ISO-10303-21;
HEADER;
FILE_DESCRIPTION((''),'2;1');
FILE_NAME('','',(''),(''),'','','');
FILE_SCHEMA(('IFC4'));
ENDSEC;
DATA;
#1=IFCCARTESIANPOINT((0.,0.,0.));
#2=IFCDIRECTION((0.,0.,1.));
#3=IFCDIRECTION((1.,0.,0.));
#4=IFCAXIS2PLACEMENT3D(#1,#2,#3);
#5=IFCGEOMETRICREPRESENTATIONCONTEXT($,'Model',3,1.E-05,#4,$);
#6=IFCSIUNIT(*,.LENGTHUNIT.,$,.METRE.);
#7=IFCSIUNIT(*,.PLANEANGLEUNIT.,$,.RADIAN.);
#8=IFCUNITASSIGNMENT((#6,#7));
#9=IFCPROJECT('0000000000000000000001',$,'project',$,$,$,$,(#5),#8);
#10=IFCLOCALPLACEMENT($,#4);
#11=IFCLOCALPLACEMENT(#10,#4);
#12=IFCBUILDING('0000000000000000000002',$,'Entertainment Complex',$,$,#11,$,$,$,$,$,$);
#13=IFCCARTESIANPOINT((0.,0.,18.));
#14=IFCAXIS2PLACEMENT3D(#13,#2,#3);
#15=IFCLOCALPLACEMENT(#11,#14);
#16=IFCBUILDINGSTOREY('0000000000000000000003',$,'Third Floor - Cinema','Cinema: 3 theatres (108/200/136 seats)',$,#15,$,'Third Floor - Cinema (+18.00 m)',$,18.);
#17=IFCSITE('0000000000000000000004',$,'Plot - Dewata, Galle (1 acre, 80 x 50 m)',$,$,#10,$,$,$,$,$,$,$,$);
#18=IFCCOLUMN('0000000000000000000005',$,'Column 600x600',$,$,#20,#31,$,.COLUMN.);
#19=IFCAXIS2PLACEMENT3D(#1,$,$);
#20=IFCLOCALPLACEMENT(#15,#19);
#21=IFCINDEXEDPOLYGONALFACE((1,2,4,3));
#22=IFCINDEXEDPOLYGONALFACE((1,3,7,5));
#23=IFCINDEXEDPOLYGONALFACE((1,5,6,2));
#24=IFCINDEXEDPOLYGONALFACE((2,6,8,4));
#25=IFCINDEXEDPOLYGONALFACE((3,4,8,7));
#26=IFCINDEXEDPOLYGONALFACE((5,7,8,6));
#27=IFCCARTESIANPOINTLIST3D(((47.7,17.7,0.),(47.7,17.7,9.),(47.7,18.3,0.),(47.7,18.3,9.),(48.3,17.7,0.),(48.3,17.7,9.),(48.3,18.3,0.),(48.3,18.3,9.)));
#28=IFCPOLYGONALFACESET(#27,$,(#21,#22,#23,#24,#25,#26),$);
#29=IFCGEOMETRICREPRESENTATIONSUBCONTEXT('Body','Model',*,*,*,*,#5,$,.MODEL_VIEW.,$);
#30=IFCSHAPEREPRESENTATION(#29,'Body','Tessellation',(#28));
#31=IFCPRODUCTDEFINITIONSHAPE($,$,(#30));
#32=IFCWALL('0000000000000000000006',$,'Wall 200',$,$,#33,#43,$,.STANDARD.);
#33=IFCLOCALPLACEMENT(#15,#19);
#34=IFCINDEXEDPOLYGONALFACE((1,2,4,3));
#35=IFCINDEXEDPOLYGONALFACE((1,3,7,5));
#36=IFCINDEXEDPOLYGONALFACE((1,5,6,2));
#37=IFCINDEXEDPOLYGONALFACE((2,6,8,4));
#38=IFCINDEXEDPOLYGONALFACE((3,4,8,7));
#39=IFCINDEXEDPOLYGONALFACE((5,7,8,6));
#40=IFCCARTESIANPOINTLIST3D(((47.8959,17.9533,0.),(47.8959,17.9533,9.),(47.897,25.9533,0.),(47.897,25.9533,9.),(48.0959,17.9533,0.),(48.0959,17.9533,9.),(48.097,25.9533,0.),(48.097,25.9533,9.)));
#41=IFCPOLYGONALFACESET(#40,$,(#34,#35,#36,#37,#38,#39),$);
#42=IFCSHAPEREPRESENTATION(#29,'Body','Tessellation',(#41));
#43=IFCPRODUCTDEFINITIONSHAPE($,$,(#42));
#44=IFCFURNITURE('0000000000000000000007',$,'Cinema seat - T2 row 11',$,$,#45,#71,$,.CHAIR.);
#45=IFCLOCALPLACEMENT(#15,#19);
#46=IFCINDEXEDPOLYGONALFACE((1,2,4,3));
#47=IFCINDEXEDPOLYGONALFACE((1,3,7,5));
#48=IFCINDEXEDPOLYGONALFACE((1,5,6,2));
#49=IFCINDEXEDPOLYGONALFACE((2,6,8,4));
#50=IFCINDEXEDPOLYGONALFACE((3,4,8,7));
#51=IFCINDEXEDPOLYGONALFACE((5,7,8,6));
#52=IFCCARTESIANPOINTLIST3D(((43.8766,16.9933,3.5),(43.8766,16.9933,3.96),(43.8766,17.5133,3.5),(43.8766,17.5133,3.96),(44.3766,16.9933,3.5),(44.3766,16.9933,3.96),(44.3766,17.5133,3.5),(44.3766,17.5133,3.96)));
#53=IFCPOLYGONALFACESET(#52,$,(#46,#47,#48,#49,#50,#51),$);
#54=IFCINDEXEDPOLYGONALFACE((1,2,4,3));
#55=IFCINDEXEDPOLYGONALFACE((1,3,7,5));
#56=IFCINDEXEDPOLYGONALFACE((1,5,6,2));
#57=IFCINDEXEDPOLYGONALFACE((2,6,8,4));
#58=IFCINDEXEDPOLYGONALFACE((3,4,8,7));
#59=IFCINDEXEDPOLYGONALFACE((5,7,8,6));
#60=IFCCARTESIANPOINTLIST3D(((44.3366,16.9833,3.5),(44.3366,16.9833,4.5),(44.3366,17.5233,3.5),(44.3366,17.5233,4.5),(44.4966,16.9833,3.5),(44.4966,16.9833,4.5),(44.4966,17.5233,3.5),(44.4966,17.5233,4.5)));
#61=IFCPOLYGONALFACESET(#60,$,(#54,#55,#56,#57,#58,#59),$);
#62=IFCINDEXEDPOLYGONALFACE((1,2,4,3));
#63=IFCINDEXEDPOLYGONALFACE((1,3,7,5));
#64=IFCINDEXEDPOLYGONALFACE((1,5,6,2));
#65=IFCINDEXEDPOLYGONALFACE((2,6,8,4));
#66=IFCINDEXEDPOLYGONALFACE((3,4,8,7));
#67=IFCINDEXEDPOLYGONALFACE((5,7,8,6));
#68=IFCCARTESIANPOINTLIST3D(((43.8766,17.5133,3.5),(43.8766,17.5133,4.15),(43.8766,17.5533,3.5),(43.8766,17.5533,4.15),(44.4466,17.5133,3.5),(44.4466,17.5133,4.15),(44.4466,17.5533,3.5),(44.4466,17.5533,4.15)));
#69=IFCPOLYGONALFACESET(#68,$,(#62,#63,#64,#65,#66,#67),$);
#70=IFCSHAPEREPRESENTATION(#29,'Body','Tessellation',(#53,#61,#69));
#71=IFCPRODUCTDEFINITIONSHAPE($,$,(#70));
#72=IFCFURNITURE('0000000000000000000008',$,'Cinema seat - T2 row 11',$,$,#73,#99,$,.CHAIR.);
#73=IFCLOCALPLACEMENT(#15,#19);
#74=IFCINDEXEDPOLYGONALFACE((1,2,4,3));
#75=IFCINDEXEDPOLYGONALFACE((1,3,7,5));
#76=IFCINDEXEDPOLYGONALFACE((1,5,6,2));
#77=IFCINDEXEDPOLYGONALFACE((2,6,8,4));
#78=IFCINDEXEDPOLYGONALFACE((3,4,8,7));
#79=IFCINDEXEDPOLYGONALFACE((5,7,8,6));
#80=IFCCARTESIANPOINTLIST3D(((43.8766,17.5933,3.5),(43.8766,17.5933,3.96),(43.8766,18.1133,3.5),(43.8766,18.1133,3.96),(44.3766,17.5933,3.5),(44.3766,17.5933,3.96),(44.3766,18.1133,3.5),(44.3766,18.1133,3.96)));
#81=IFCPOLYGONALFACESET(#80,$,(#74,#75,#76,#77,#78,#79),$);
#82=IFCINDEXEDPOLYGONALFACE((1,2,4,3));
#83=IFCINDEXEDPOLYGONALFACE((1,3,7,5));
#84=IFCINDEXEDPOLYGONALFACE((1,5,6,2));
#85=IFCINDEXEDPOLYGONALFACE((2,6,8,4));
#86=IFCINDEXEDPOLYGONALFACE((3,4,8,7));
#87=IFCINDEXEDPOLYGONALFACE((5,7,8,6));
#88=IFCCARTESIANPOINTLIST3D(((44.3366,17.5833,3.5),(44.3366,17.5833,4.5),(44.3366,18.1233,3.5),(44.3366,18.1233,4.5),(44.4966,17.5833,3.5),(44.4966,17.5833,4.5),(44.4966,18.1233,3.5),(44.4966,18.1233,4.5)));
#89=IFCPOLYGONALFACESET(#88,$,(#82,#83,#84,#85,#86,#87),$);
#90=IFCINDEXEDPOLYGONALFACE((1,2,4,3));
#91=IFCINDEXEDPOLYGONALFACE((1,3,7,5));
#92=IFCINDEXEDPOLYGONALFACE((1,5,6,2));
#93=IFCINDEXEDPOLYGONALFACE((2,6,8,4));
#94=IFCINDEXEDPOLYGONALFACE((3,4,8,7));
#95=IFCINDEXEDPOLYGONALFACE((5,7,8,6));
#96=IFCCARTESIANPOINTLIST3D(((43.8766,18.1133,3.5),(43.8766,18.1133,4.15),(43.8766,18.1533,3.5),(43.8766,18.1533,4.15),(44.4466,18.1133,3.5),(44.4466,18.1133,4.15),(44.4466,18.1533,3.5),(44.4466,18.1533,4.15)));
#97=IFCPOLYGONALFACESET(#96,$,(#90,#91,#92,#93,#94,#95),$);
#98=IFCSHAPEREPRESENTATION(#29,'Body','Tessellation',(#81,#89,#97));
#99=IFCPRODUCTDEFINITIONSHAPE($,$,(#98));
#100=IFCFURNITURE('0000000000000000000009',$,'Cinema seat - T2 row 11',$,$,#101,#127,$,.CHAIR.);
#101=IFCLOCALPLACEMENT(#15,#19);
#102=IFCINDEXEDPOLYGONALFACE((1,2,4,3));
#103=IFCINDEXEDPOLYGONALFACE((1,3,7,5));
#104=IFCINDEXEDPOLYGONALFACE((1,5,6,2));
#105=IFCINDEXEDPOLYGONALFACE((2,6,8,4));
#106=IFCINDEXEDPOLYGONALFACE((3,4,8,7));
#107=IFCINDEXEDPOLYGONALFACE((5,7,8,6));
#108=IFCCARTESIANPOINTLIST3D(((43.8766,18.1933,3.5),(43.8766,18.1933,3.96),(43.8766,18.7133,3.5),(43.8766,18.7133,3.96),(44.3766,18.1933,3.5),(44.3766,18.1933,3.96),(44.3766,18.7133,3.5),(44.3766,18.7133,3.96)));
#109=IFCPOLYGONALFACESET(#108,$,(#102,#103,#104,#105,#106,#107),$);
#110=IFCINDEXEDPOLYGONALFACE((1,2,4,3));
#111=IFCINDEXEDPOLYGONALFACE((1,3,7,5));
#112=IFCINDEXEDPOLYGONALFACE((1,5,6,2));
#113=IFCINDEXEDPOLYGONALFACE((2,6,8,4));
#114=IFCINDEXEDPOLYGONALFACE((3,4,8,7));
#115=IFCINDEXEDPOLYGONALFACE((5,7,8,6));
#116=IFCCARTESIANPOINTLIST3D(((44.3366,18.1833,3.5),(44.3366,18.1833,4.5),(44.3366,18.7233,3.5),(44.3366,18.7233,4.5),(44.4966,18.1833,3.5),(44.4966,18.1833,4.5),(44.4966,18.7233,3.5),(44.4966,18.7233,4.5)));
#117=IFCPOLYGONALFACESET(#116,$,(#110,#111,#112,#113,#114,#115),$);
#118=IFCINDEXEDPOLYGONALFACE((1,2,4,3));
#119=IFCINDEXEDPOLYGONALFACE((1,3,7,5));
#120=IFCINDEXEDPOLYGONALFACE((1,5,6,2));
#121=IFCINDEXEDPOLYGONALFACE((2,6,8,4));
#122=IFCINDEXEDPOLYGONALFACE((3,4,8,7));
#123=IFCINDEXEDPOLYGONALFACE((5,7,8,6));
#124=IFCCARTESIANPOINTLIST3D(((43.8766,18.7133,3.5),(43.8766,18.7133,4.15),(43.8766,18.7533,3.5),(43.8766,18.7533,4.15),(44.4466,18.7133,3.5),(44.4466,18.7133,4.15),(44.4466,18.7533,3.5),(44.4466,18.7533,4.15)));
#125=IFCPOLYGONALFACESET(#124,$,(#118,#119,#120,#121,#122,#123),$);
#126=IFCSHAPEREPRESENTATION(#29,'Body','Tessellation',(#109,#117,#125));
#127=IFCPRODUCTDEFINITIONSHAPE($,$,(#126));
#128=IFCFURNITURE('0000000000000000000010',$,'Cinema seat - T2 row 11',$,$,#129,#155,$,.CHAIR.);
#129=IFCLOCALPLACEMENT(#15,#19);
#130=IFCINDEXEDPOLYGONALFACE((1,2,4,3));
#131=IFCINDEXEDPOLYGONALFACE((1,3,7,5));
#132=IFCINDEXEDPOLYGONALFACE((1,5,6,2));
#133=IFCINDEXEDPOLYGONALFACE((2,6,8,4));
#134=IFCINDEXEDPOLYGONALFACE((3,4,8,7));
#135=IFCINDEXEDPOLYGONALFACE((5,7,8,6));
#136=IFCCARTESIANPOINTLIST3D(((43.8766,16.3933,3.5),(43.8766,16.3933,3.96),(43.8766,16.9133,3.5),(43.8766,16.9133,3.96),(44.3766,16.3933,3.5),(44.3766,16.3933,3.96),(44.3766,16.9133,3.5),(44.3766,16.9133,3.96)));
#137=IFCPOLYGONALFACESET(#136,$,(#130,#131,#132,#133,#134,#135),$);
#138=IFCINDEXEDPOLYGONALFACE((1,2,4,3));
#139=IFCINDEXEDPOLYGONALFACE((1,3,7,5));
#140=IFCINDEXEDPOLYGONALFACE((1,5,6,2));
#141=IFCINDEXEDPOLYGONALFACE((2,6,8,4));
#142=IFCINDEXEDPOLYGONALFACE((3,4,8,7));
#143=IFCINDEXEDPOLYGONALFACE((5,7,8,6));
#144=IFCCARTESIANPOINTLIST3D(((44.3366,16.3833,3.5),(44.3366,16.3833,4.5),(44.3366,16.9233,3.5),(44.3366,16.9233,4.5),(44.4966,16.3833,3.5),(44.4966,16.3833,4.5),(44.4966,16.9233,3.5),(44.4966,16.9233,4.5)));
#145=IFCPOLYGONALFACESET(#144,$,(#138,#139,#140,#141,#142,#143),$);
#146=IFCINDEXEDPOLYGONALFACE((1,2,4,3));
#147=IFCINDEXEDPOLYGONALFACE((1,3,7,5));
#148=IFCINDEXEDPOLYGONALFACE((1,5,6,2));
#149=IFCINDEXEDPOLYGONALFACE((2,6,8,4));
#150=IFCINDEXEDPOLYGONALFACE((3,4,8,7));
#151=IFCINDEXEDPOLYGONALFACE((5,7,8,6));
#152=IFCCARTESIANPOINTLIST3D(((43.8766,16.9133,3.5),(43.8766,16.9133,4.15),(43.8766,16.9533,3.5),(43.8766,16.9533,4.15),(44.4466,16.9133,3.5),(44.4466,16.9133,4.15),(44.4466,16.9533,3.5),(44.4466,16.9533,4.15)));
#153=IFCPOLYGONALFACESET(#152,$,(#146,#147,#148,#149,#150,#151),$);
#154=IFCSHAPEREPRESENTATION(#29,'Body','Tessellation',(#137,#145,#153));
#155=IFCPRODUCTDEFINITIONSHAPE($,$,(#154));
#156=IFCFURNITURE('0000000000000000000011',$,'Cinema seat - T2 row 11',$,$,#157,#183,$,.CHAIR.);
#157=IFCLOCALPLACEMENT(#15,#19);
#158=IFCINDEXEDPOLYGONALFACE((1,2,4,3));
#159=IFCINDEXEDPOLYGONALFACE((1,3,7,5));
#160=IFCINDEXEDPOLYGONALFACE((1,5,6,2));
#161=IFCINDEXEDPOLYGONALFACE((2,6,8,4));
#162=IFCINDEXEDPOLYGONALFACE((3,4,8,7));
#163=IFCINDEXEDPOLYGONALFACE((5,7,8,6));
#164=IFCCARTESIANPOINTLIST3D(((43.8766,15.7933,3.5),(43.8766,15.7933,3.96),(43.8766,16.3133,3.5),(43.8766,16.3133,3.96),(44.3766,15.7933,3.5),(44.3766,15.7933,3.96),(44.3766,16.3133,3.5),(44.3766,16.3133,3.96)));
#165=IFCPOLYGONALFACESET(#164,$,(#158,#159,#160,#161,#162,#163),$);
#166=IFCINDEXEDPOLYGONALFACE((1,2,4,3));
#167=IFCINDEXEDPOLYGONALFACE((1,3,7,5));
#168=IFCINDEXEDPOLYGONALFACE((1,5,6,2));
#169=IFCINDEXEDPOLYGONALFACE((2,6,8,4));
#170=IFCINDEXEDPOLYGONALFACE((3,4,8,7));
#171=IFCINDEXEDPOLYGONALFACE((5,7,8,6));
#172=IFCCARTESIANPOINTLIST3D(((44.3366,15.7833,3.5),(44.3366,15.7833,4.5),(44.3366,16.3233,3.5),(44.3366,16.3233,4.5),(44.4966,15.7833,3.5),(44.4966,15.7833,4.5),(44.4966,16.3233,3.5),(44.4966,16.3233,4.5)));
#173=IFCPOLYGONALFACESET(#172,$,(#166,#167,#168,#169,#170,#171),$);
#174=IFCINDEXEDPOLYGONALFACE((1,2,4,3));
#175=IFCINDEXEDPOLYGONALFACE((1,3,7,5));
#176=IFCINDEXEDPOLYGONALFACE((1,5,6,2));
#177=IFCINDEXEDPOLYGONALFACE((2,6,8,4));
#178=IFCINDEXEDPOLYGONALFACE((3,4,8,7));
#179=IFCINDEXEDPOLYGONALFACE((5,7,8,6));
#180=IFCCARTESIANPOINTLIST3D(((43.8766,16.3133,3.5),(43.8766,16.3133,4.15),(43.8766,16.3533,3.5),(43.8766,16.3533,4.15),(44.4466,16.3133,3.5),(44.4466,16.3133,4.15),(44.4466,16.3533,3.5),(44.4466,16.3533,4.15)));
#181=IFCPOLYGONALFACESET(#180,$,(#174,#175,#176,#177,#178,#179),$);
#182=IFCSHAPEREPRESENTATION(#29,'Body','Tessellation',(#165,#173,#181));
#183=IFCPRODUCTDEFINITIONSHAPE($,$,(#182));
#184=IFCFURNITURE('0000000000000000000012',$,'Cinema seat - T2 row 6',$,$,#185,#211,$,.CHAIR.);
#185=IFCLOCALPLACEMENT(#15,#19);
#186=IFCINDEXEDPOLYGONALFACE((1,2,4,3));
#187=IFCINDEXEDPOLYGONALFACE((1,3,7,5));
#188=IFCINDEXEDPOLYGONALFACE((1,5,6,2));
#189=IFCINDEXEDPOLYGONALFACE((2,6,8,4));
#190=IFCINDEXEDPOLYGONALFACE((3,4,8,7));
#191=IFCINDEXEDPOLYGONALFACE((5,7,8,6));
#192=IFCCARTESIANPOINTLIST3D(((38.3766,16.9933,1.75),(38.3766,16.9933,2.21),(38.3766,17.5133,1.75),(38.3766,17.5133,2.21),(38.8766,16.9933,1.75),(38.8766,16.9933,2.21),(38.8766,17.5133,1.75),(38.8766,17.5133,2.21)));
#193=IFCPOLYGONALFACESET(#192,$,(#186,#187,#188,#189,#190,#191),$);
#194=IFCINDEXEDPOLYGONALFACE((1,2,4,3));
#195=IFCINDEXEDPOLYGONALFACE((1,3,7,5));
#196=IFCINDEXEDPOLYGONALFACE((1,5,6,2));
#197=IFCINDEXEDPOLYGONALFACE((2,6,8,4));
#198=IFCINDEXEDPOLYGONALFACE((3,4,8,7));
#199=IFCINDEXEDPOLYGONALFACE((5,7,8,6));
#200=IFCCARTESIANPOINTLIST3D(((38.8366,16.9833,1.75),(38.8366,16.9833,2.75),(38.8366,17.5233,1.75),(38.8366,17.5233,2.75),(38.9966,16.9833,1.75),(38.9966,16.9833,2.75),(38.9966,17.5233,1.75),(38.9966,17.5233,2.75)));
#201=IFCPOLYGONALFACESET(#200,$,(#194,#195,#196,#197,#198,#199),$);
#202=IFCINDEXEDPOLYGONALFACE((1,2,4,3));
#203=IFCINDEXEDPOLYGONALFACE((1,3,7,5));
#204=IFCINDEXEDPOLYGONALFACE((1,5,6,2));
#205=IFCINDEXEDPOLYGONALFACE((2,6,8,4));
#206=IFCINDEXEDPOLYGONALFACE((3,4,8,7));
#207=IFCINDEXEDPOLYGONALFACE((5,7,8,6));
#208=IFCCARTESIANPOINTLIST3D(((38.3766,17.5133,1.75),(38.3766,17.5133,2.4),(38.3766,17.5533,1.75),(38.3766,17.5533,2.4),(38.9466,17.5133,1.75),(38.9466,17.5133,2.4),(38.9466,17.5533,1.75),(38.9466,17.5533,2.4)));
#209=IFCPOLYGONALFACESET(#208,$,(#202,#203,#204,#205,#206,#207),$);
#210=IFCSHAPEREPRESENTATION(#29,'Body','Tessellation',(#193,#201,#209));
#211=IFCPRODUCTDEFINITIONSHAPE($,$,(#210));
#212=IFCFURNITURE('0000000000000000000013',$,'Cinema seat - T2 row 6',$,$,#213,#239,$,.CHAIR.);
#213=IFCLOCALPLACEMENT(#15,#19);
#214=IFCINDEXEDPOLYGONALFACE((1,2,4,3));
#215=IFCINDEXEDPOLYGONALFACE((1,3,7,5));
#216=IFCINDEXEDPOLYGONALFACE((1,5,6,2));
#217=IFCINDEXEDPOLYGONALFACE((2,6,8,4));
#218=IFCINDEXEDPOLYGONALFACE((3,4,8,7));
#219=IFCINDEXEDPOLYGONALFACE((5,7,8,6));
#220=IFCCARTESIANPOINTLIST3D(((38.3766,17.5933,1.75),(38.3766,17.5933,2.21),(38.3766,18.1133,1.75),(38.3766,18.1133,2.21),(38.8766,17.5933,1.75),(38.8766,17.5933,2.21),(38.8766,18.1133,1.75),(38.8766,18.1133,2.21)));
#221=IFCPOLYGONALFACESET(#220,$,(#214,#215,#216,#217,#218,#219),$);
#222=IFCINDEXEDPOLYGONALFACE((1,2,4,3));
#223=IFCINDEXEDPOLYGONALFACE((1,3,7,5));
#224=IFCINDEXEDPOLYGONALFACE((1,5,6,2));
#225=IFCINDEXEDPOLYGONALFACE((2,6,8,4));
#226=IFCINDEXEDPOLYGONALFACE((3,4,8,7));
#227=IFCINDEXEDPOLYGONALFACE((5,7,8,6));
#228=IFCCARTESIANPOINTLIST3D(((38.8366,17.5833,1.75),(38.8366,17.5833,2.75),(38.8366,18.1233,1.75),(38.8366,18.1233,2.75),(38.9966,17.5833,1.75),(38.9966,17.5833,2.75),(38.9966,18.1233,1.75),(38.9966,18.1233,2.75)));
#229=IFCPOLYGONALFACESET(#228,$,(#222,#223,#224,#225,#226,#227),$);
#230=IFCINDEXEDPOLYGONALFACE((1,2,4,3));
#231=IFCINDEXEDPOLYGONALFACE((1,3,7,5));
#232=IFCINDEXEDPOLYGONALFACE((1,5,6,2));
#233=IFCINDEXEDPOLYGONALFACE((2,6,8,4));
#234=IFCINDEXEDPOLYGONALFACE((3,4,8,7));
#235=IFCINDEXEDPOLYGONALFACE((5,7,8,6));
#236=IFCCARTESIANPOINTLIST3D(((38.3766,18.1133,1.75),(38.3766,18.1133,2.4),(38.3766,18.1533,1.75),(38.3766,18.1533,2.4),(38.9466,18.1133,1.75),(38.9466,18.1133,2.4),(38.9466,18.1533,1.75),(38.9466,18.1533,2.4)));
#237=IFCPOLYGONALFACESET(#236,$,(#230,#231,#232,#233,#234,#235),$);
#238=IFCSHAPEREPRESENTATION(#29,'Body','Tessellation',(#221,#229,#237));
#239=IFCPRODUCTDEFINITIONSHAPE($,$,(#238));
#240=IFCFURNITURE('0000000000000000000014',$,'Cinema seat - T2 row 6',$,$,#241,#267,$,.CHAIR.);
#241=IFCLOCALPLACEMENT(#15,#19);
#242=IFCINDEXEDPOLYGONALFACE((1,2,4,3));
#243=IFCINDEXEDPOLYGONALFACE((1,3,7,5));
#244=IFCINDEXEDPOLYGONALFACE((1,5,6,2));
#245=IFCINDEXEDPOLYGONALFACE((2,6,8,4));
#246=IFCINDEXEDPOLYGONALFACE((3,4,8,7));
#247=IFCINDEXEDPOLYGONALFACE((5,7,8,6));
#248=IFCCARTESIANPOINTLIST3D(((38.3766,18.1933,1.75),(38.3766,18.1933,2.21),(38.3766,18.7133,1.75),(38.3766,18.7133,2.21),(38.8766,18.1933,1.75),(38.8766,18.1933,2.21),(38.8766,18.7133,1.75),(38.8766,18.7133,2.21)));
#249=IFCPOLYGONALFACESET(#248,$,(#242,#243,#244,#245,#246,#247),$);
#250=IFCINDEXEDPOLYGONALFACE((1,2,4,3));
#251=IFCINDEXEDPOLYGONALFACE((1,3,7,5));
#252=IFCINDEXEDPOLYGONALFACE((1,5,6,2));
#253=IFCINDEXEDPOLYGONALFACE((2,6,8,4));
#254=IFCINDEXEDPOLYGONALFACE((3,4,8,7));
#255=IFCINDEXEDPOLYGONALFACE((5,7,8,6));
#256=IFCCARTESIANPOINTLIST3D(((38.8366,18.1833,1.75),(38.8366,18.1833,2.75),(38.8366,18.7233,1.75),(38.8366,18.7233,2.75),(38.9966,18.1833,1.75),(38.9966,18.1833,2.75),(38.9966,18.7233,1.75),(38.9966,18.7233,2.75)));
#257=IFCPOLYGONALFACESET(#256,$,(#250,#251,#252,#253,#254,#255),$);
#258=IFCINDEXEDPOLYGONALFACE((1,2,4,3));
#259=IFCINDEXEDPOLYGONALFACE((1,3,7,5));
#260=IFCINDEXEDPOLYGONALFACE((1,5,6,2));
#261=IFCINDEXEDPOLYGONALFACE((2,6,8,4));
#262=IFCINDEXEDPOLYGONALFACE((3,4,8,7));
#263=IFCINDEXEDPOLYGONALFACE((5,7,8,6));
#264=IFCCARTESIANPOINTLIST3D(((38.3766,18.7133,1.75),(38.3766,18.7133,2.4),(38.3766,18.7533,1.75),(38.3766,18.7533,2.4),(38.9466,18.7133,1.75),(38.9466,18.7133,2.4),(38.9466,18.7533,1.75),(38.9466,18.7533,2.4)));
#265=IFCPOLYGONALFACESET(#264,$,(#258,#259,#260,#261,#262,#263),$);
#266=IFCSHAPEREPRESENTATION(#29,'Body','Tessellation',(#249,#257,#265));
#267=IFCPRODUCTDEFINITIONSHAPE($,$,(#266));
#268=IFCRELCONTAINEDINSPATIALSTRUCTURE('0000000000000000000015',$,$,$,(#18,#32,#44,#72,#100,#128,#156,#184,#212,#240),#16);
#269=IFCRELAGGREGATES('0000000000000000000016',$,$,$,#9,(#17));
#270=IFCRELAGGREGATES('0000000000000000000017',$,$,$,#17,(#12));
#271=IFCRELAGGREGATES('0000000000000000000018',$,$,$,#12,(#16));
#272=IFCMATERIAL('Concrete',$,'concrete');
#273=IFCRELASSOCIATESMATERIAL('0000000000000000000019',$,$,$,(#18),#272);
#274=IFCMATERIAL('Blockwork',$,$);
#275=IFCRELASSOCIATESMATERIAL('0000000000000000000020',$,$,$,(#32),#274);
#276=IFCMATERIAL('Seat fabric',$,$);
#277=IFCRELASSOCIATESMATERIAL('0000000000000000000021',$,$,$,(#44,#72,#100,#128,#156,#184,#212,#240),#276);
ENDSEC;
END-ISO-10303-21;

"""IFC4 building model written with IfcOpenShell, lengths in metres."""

from ifc_helpers import new_model, si_unit, frame, origin_with_axes, place, context, subcontext, project, spatial, polyline, outline, extrude, material, element, save


model = new_model("IFC4")

# Units and contexts
model_context = context("Model", 3, precision=1e-05, world=origin_with_axes())
body_context = subcontext(model_context, "Body", "Model", "MODEL_VIEW")
ifc_project = project(units=[si_unit("LENGTHUNIT", "METRE"), si_unit("PLANEANGLEUNIT", "RADIAN")], contexts=[model_context])

# Site, building, storey
site_placement = place(None, origin_with_axes())
site = spatial("IfcSite", under=ifc_project, at=site_placement, Name="Plot - Dewata, Galle (1 acre, 80 x 50 m)")
building_placement = place(site_placement, origin_with_axes())
building = spatial("IfcBuilding", under=site, at=building_placement, Name="Entertainment Complex")
storey_placement = place(building_placement, frame((0.0, 0.0, 18.0), z_axis=(0.0, 0.0, 1.0), x_axis=(1.0, 0.0, 0.0)))
storey = spatial("IfcBuildingStorey", under=building, at=storey_placement, Name="Third Floor - Cinema", Description="Cinema: 3 theatres (108/200/136 seats)", LongName="Third Floor - Cinema (+18.00 m)", Elevation=18.0)

# Column
ifc_material_1 = material(Name="Concrete", Category="concrete")
column_placement = place(storey_placement, frame((48.0, 18.0, 0.0), z_axis=(0.0, 0.0, 1.0), x_axis=(1.0, 0.0, 0.0)))
element("IfcColumn", 1, at=column_placement, inside=storey, material=ifc_material_1, Name="Column 600x600", PredefinedType="COLUMN", context=body_context, shape_type="SweptSolid", body=[
    extrude(outline(polyline([(-0.3, -0.3), (0.3, -0.3), (0.3, 0.3), (-0.3, 0.3), (-0.3, -0.3)])), origin_with_axes(), (0.0, 0.0, 1.0), 9.0),
])

# Wall
ifc_material_2 = material(Name="Blockwork")
wall_placement = place(storey_placement, frame((47.9959, 17.9533, 0.0), z_axis=(0.0, 0.0, 1.0), x_axis=(0.000137, 1.0, 0.0)))
element("IfcWall", 2, at=wall_placement, inside=storey, material=ifc_material_2, Name="Wall 200", PredefinedType="STANDARD", context=body_context, shape_type="SweptSolid", body=[
    extrude(outline(polyline([(0.0, -0.1), (8.0, -0.1), (8.0, 0.1), (0.0, 0.1), (0.0, -0.1)])), origin_with_axes(), (0.0, 0.0, 1.0), 9.0),
])

# Furniture
ifc_material_3 = material(Name="Seat fabric")
for number, where, z_axis, x_axis, name in (
    (3, (44.4966, 17.2533, 3.5), (0.0, 0.0, 1.0), (1.0, 0.0, 0.0), "Cinema seat - T2 row 11"),
    (4, (44.4966, 17.8533, 3.5), (0.0, 0.0, 1.0), (1.0, 0.0, 0.0), "Cinema seat - T2 row 11"),
    (5, (44.4966, 18.4533, 3.5), (0.0, 0.0, 1.0), (1.0, 0.0, 0.0), "Cinema seat - T2 row 11"),
    (6, (44.4966, 16.6533, 3.5), (0.0, 0.0, 1.0), (1.0, 0.0, 0.0), "Cinema seat - T2 row 11"),
    (7, (44.4966, 16.0533, 3.5), (0.0, 0.0, 1.0), (1.0, 0.0, 0.0), "Cinema seat - T2 row 11"),
    (8, (38.9966, 17.2533, 1.75), (0.0, 0.0, 1.0), (1.0, 0.0, 0.0), "Cinema seat - T2 row 6"),
    (9, (38.9966, 17.8533, 1.75), (0.0, 0.0, 1.0), (1.0, 0.0, 0.0), "Cinema seat - T2 row 6"),
    (10, (38.9966, 18.4533, 1.75), (0.0, 0.0, 1.0), (1.0, 0.0, 0.0), "Cinema seat - T2 row 6"),
):
    element("IfcFurniture", number, at=place(storey_placement, frame(where, z_axis=z_axis, x_axis=x_axis)), inside=storey, material=ifc_material_3, Name=name, PredefinedType="CHAIR", context=body_context, shape_type="SweptSolid", body=[
        extrude(outline(polyline([(-0.62, -0.26), (-0.12, -0.26), (-0.12, 0.26), (-0.62, 0.26), (-0.62, -0.26)])), origin_with_axes(), (0.0, 0.0, 1.0), 0.46),
        extrude(outline(polyline([(-0.16, -0.27), (0.0, -0.27), (0.0, 0.27), (-0.16, 0.27), (-0.16, -0.27)])), origin_with_axes(), (0.0, 0.0, 1.0), 1.0),
        extrude(outline(polyline([(-0.62, 0.26), (-0.05, 0.26), (-0.05, 0.3), (-0.62, 0.3), (-0.62, 0.26)])), origin_with_axes(), (0.0, 0.0, 1.0), 0.65),
    ])

save(model, "model.ifc")
